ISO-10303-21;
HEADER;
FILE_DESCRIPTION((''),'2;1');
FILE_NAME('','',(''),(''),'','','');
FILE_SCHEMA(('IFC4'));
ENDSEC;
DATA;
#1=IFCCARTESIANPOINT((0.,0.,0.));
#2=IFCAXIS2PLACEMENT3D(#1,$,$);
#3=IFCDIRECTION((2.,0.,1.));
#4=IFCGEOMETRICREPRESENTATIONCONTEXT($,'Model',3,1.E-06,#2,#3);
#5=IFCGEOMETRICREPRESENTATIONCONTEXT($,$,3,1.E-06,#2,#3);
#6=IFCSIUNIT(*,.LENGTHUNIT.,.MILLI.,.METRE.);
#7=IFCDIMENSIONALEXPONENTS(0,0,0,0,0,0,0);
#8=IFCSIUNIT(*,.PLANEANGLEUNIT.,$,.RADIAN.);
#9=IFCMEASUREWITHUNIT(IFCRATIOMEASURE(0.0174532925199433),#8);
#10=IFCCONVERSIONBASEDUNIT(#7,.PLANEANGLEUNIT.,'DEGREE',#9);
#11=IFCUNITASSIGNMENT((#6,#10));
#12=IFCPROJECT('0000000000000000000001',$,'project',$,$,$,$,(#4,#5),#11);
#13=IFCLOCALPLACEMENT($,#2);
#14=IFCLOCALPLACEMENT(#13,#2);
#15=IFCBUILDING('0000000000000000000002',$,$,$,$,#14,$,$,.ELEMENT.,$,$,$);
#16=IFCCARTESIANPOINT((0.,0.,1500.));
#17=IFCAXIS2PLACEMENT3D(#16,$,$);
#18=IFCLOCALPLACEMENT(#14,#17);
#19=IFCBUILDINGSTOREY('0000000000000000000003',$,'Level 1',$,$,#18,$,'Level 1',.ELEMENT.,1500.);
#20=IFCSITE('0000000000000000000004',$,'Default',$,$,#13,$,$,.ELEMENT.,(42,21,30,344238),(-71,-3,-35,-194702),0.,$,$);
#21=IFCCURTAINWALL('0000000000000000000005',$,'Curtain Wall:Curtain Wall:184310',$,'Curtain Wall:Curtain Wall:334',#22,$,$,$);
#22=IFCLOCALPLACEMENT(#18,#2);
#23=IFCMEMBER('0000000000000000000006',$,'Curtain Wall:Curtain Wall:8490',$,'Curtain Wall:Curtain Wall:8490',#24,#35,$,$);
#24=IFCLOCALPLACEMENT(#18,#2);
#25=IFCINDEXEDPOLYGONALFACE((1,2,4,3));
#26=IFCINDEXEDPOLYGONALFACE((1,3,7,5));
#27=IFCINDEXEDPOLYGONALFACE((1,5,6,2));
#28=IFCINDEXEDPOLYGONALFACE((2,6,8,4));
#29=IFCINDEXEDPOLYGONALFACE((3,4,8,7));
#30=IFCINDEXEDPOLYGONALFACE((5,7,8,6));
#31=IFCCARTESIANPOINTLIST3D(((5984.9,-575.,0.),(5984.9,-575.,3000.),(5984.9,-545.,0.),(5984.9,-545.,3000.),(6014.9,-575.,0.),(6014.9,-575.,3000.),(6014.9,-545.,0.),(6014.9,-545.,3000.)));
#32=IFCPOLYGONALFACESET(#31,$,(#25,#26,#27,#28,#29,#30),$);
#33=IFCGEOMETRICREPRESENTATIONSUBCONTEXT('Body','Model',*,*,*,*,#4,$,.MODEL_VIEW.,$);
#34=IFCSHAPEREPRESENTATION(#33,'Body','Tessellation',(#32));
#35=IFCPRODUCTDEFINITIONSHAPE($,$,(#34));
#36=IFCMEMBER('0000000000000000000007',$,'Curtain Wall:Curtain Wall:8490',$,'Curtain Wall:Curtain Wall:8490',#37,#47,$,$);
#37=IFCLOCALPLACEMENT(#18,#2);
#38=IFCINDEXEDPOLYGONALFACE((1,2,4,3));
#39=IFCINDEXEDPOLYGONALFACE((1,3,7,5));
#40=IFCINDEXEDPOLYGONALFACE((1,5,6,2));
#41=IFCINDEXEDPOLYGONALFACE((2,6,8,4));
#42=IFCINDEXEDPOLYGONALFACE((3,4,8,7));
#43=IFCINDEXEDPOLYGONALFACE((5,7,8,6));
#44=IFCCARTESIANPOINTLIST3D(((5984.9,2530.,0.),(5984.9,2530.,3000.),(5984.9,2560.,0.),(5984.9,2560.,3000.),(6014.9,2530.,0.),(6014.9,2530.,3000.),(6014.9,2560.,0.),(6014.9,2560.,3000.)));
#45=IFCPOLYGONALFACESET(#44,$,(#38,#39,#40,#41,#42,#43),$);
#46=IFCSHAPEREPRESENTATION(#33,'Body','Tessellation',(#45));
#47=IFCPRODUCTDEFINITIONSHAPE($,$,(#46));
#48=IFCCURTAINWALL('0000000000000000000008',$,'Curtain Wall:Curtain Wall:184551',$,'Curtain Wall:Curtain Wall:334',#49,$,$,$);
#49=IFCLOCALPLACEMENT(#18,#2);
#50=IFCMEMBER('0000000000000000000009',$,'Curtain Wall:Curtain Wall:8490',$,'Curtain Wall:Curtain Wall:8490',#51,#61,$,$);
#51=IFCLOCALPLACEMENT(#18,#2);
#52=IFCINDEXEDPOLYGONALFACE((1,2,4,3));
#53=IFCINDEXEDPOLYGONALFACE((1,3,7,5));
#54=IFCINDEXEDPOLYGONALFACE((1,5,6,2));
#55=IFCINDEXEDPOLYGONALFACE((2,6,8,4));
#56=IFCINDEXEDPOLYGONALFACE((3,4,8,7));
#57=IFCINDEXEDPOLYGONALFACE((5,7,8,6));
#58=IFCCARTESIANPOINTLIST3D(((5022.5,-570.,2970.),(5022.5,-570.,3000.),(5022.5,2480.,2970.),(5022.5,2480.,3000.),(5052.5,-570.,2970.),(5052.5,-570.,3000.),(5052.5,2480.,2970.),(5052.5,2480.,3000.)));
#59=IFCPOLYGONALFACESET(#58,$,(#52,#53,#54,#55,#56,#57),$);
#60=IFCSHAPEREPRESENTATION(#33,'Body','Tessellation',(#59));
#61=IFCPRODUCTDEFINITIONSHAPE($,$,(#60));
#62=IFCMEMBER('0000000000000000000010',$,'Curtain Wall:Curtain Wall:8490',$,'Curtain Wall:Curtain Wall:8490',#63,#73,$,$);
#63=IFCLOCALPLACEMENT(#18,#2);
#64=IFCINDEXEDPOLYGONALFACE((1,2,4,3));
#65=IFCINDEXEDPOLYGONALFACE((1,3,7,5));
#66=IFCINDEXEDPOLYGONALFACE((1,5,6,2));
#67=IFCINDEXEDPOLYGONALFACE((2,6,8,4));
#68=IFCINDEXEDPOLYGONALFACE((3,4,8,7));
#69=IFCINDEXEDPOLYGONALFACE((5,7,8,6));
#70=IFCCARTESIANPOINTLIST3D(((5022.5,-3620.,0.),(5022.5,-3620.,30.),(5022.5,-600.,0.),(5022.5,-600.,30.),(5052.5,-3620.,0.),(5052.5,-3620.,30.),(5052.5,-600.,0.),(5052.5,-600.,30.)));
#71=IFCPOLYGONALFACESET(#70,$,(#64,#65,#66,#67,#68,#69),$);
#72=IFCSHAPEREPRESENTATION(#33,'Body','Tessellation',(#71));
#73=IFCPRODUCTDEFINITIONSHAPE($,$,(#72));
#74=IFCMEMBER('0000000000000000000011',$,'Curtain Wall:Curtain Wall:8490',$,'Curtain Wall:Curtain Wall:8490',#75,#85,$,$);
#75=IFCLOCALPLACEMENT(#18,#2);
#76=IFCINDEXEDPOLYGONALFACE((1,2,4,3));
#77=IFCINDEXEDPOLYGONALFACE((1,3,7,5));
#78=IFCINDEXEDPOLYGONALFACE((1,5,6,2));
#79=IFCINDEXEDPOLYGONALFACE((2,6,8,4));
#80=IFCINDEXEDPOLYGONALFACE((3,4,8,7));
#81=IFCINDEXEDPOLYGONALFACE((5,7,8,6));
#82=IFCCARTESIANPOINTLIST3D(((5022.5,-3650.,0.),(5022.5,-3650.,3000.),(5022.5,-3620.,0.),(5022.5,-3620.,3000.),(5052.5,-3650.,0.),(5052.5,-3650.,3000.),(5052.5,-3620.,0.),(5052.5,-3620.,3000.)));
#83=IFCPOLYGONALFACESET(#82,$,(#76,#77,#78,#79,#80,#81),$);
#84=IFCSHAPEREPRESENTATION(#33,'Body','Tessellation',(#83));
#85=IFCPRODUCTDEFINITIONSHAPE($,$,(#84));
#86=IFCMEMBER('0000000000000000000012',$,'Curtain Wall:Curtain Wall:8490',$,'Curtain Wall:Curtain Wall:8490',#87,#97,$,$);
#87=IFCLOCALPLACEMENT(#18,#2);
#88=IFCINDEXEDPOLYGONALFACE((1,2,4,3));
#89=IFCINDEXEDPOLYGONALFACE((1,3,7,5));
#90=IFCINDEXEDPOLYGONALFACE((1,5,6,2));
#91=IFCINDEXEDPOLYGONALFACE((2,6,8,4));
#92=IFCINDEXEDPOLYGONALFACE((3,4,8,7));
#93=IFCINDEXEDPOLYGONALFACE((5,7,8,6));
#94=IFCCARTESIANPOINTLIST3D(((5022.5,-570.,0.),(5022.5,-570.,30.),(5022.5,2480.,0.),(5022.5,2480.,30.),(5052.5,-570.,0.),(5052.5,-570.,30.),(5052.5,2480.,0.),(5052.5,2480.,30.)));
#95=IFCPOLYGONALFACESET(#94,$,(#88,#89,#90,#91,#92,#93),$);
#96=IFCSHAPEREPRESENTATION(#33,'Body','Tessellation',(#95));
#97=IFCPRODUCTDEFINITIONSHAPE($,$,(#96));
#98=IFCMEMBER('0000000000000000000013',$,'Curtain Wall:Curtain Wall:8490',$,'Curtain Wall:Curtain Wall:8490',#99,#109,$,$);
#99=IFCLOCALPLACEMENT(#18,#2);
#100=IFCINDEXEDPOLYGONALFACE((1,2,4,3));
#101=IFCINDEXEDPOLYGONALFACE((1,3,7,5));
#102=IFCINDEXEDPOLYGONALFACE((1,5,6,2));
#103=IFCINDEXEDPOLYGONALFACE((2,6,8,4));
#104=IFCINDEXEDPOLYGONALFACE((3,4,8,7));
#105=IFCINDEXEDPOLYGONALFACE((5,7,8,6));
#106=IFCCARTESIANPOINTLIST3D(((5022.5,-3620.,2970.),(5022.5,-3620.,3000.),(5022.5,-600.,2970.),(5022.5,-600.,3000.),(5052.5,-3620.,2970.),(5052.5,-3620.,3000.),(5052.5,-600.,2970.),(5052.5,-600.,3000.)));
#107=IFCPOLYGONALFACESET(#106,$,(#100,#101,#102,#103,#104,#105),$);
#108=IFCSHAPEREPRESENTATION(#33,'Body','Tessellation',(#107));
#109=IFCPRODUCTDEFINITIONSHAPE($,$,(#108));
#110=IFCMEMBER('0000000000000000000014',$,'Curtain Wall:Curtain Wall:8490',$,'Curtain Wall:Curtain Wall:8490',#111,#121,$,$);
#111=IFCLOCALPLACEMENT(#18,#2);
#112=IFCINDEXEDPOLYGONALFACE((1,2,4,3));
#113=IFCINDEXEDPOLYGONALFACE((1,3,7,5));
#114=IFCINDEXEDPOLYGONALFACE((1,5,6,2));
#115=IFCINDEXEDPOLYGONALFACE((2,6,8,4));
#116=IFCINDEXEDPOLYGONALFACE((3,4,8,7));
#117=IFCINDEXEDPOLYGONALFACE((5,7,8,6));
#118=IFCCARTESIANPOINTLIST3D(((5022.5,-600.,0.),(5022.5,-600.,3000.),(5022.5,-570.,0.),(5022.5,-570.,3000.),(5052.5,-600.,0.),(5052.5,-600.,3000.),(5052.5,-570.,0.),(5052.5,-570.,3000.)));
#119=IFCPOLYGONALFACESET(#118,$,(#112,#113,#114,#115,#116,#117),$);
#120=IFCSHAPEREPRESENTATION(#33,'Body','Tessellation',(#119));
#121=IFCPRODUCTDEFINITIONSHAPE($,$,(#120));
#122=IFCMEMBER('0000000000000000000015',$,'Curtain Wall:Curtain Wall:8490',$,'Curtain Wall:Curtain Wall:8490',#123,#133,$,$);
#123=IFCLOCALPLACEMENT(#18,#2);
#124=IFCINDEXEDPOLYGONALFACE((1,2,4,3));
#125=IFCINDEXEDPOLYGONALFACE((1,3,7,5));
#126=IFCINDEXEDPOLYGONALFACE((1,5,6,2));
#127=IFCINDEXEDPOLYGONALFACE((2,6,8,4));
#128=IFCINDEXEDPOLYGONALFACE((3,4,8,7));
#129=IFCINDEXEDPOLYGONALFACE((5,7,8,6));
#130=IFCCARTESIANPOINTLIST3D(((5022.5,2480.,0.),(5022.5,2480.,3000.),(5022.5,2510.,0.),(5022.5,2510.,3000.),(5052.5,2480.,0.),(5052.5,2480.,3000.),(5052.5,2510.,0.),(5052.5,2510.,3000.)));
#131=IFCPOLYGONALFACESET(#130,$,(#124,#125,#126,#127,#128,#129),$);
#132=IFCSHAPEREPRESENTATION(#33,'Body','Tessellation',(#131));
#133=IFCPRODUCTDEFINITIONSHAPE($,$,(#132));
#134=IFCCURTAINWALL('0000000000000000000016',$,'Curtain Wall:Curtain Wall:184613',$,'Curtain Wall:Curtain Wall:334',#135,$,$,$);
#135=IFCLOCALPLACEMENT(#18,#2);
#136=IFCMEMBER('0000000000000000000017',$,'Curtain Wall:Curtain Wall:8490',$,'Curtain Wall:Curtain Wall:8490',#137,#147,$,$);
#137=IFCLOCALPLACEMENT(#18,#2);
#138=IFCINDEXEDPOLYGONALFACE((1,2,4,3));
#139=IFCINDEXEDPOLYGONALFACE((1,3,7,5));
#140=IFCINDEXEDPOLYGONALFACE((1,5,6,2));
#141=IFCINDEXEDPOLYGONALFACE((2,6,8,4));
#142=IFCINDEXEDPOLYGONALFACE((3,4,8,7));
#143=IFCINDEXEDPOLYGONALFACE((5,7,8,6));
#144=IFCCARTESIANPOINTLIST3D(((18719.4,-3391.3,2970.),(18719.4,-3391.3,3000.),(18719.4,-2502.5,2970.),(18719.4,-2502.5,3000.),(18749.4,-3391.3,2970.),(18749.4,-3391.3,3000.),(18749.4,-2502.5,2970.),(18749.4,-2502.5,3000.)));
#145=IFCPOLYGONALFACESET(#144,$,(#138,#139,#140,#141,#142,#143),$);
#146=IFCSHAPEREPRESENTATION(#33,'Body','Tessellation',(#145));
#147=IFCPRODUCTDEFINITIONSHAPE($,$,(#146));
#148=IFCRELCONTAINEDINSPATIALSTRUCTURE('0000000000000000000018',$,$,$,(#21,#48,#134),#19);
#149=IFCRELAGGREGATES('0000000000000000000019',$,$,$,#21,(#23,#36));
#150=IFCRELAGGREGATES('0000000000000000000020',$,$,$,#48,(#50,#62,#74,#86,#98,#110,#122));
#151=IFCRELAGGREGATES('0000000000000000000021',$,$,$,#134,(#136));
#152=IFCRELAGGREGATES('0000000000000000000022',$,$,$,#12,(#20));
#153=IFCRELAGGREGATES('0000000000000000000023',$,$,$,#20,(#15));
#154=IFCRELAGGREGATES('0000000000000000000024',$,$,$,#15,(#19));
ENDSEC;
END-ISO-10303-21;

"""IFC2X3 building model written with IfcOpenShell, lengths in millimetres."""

from ifc_helpers import new_model, entity, si_unit, converted_unit, direction, frame, frame_2d, origin, origin_2d_with_axis, place, context, subcontext, project, spatial, rectangle, extrude, element, aggregate, save


model = new_model("IFC2X3")

# Units and contexts
model_context = context("Model", 3, precision=1e-06, world=origin(), true_north=direction((2.0, 0.0, 1.0)))
context_of_model = context(None, 3, precision=1e-06, world=origin(), true_north=direction((2.0, 0.0, 1.0)))
body_context = subcontext(model_context, "Body", "Model", "MODEL_VIEW")
ifc_project = project(units=[si_unit("LENGTHUNIT", "METRE", prefix="MILLI"), converted_unit("PLANEANGLEUNIT", "DEGREE", entity("IfcRatioMeasure", 0.0174532925199433), si_unit("PLANEANGLEUNIT", "RADIAN"), dimensions=[0, 0, 0, 0, 0, 0, 0])], contexts=[model_context, context_of_model])

# Site, building, storey
site_placement = place(None, origin())
site = spatial("IfcSite", under=ifc_project, at=site_placement, Name="Default", CompositionType="ELEMENT", RefLatitude=(42, 21, 30, 344238), RefLongitude=(-71, -3, -35, -194702), RefElevation=0.0)
building_placement = place(site_placement, origin())
building = spatial("IfcBuilding", under=site, at=building_placement, CompositionType="ELEMENT")
storey_placement = place(building_placement, frame((0.0, 0.0, 1500.0)))
storey = spatial("IfcBuildingStorey", under=building, at=storey_placement, Name="Level 1", LongName="Level 1", CompositionType="ELEMENT", Elevation=1500.0)

# Curtain walls, members
curtain_wall_1_placement = place(storey_placement, origin())
curtain_wall_1 = element("IfcCurtainWall", 1, at=curtain_wall_1_placement, inside=storey, Name="Curtain Wall:Curtain Wall:184310", ObjectType="Curtain Wall:Curtain Wall:334")
member_1_placement = place(storey_placement, origin())
member_1 = element("IfcMember", 2, at=member_1_placement, Name="Curtain Wall:Curtain Wall:8490", ObjectType="Curtain Wall:Curtain Wall:8490", context=body_context, shape_type="SweptSolid", body=[
    extrude(rectangle(XDim=30.0, YDim=30.0, at=origin_2d_with_axis()), frame((5999.9, -560.0, 0.0)), (0.0, 0.0, 1.0), 3000.0),
])
member_2_placement = place(storey_placement, origin())
member_2 = element("IfcMember", 3, at=member_2_placement, Name="Curtain Wall:Curtain Wall:8490", ObjectType="Curtain Wall:Curtain Wall:8490", context=body_context, shape_type="SweptSolid", body=[
    extrude(rectangle(XDim=30.0, YDim=30.0, at=frame_2d((0.0, 0.0), x_axis=(1.0, 0.0))), frame((5999.9, 2545.0, 0.0), z_axis=(0.0, 0.0, 1.0), x_axis=(0.0, -1.0, 0.0)), (0.0, 0.0, 1.0), 3000.0),
])
aggregate(curtain_wall_1, [member_1, member_2])
curtain_wall_2_placement = place(storey_placement, origin())
curtain_wall_2 = element("IfcCurtainWall", 4, at=curtain_wall_2_placement, inside=storey, Name="Curtain Wall:Curtain Wall:184551", ObjectType="Curtain Wall:Curtain Wall:334")
member_3_placement = place(storey_placement, origin())
member_3 = element("IfcMember", 5, at=member_3_placement, Name="Curtain Wall:Curtain Wall:8490", ObjectType="Curtain Wall:Curtain Wall:8490", context=body_context, shape_type="SweptSolid", body=[
    extrude(rectangle(XDim=3050.0, YDim=30.0, at=frame_2d((0.0, 0.0), x_axis=(1.0, 0.0))), frame((5037.5, 955.0, 2970.0), z_axis=(0.0, 0.0, 1.0), x_axis=(0.0, 1.0, 0.0)), (0.0, 0.0, 1.0), 30.0),
])
member_4_placement = place(storey_placement, origin())
member_4 = element("IfcMember", 6, at=member_4_placement, Name="Curtain Wall:Curtain Wall:8490", ObjectType="Curtain Wall:Curtain Wall:8490", context=body_context, shape_type="SweptSolid", body=[
    extrude(rectangle(XDim=3020.0, YDim=30.0, at=origin_2d_with_axis()), frame((5037.5, -2110.0, 0.0), z_axis=(0.0, 0.0, 1.0), x_axis=(0.0, -1.0, 0.0)), (0.0, 0.0, 1.0), 30.0),
])
member_5_placement = place(storey_placement, origin())
member_5 = element("IfcMember", 7, at=member_5_placement, Name="Curtain Wall:Curtain Wall:8490", ObjectType="Curtain Wall:Curtain Wall:8490", context=body_context, shape_type="SweptSolid", body=[
    extrude(rectangle(XDim=30.0, YDim=30.0, at=frame_2d((0.0, 0.0), x_axis=(1.0, 0.0))), frame((5037.5, -3635.0, 0.0)), (0.0, 0.0, 1.0), 3000.0),
])
member_6_placement = place(storey_placement, origin())
member_6 = element("IfcMember", 8, at=member_6_placement, Name="Curtain Wall:Curtain Wall:8490", ObjectType="Curtain Wall:Curtain Wall:8490", context=body_context, shape_type="SweptSolid", body=[
    extrude(rectangle(XDim=3050.0, YDim=30.0, at=origin_2d_with_axis()), frame((5037.5, 955.0, 0.0), z_axis=(0.0, 0.0, 1.0), x_axis=(0.0, -1.0, 0.0)), (0.0, 0.0, 1.0), 30.0),
])
member_7_placement = place(storey_placement, origin())
member_7 = element("IfcMember", 9, at=member_7_placement, Name="Curtain Wall:Curtain Wall:8490", ObjectType="Curtain Wall:Curtain Wall:8490", context=body_context, shape_type="SweptSolid", body=[
    extrude(rectangle(XDim=3020.0, YDim=30.0, at=origin_2d_with_axis()), frame((5037.5, -2110.0, 2970.0), z_axis=(0.0, 0.0, 1.0), x_axis=(0.0, 1.0, 0.0)), (0.0, 0.0, 1.0), 30.0),
])
member_8_placement = place(storey_placement, origin())
member_8 = element("IfcMember", 10, at=member_8_placement, Name="Curtain Wall:Curtain Wall:8490", ObjectType="Curtain Wall:Curtain Wall:8490", context=body_context, shape_type="SweptSolid", body=[
    extrude(rectangle(XDim=30.0, YDim=30.0, at=origin_2d_with_axis()), frame((5037.5, -585.0, 0.0)), (0.0, 0.0, 1.0), 3000.0),
])
member_9_placement = place(storey_placement, origin())
member_9 = element("IfcMember", 11, at=member_9_placement, Name="Curtain Wall:Curtain Wall:8490", ObjectType="Curtain Wall:Curtain Wall:8490", context=body_context, shape_type="SweptSolid", body=[
    extrude(rectangle(XDim=30.0, YDim=30.0, at=frame_2d((0.0, 0.0), x_axis=(1.0, 0.0))), frame((5037.5, 2495.0, 0.0), z_axis=(0.0, 0.0, 1.0), x_axis=(0.0, -1.0, 0.0)), (0.0, 0.0, 1.0), 3000.0),
])
aggregate(curtain_wall_2, [member_3, member_4, member_5, member_6, member_7, member_8, member_9])

# Curtain wall, member
curtain_wall_3_placement = place(storey_placement, origin())
curtain_wall_3 = element("IfcCurtainWall", 12, at=curtain_wall_3_placement, inside=storey, Name="Curtain Wall:Curtain Wall:184613", ObjectType="Curtain Wall:Curtain Wall:334")
member_10_placement = place(storey_placement, origin())
member_10 = element("IfcMember", 13, at=member_10_placement, Name="Curtain Wall:Curtain Wall:8490", ObjectType="Curtain Wall:Curtain Wall:8490", context=body_context, shape_type="SweptSolid", body=[
    extrude(rectangle(XDim=888.8, YDim=30.0, at=frame_2d((0.0, 0.0), x_axis=(1.0, 0.0))), frame((18734.4, -2946.9, 2970.0), z_axis=(0.0, 0.0, 1.0), x_axis=(0.0, 1.0, 0.0)), (0.0, 0.0, 1.0), 30.0),
])
aggregate(curtain_wall_3, [member_10])

save(model, "model.ifc")
